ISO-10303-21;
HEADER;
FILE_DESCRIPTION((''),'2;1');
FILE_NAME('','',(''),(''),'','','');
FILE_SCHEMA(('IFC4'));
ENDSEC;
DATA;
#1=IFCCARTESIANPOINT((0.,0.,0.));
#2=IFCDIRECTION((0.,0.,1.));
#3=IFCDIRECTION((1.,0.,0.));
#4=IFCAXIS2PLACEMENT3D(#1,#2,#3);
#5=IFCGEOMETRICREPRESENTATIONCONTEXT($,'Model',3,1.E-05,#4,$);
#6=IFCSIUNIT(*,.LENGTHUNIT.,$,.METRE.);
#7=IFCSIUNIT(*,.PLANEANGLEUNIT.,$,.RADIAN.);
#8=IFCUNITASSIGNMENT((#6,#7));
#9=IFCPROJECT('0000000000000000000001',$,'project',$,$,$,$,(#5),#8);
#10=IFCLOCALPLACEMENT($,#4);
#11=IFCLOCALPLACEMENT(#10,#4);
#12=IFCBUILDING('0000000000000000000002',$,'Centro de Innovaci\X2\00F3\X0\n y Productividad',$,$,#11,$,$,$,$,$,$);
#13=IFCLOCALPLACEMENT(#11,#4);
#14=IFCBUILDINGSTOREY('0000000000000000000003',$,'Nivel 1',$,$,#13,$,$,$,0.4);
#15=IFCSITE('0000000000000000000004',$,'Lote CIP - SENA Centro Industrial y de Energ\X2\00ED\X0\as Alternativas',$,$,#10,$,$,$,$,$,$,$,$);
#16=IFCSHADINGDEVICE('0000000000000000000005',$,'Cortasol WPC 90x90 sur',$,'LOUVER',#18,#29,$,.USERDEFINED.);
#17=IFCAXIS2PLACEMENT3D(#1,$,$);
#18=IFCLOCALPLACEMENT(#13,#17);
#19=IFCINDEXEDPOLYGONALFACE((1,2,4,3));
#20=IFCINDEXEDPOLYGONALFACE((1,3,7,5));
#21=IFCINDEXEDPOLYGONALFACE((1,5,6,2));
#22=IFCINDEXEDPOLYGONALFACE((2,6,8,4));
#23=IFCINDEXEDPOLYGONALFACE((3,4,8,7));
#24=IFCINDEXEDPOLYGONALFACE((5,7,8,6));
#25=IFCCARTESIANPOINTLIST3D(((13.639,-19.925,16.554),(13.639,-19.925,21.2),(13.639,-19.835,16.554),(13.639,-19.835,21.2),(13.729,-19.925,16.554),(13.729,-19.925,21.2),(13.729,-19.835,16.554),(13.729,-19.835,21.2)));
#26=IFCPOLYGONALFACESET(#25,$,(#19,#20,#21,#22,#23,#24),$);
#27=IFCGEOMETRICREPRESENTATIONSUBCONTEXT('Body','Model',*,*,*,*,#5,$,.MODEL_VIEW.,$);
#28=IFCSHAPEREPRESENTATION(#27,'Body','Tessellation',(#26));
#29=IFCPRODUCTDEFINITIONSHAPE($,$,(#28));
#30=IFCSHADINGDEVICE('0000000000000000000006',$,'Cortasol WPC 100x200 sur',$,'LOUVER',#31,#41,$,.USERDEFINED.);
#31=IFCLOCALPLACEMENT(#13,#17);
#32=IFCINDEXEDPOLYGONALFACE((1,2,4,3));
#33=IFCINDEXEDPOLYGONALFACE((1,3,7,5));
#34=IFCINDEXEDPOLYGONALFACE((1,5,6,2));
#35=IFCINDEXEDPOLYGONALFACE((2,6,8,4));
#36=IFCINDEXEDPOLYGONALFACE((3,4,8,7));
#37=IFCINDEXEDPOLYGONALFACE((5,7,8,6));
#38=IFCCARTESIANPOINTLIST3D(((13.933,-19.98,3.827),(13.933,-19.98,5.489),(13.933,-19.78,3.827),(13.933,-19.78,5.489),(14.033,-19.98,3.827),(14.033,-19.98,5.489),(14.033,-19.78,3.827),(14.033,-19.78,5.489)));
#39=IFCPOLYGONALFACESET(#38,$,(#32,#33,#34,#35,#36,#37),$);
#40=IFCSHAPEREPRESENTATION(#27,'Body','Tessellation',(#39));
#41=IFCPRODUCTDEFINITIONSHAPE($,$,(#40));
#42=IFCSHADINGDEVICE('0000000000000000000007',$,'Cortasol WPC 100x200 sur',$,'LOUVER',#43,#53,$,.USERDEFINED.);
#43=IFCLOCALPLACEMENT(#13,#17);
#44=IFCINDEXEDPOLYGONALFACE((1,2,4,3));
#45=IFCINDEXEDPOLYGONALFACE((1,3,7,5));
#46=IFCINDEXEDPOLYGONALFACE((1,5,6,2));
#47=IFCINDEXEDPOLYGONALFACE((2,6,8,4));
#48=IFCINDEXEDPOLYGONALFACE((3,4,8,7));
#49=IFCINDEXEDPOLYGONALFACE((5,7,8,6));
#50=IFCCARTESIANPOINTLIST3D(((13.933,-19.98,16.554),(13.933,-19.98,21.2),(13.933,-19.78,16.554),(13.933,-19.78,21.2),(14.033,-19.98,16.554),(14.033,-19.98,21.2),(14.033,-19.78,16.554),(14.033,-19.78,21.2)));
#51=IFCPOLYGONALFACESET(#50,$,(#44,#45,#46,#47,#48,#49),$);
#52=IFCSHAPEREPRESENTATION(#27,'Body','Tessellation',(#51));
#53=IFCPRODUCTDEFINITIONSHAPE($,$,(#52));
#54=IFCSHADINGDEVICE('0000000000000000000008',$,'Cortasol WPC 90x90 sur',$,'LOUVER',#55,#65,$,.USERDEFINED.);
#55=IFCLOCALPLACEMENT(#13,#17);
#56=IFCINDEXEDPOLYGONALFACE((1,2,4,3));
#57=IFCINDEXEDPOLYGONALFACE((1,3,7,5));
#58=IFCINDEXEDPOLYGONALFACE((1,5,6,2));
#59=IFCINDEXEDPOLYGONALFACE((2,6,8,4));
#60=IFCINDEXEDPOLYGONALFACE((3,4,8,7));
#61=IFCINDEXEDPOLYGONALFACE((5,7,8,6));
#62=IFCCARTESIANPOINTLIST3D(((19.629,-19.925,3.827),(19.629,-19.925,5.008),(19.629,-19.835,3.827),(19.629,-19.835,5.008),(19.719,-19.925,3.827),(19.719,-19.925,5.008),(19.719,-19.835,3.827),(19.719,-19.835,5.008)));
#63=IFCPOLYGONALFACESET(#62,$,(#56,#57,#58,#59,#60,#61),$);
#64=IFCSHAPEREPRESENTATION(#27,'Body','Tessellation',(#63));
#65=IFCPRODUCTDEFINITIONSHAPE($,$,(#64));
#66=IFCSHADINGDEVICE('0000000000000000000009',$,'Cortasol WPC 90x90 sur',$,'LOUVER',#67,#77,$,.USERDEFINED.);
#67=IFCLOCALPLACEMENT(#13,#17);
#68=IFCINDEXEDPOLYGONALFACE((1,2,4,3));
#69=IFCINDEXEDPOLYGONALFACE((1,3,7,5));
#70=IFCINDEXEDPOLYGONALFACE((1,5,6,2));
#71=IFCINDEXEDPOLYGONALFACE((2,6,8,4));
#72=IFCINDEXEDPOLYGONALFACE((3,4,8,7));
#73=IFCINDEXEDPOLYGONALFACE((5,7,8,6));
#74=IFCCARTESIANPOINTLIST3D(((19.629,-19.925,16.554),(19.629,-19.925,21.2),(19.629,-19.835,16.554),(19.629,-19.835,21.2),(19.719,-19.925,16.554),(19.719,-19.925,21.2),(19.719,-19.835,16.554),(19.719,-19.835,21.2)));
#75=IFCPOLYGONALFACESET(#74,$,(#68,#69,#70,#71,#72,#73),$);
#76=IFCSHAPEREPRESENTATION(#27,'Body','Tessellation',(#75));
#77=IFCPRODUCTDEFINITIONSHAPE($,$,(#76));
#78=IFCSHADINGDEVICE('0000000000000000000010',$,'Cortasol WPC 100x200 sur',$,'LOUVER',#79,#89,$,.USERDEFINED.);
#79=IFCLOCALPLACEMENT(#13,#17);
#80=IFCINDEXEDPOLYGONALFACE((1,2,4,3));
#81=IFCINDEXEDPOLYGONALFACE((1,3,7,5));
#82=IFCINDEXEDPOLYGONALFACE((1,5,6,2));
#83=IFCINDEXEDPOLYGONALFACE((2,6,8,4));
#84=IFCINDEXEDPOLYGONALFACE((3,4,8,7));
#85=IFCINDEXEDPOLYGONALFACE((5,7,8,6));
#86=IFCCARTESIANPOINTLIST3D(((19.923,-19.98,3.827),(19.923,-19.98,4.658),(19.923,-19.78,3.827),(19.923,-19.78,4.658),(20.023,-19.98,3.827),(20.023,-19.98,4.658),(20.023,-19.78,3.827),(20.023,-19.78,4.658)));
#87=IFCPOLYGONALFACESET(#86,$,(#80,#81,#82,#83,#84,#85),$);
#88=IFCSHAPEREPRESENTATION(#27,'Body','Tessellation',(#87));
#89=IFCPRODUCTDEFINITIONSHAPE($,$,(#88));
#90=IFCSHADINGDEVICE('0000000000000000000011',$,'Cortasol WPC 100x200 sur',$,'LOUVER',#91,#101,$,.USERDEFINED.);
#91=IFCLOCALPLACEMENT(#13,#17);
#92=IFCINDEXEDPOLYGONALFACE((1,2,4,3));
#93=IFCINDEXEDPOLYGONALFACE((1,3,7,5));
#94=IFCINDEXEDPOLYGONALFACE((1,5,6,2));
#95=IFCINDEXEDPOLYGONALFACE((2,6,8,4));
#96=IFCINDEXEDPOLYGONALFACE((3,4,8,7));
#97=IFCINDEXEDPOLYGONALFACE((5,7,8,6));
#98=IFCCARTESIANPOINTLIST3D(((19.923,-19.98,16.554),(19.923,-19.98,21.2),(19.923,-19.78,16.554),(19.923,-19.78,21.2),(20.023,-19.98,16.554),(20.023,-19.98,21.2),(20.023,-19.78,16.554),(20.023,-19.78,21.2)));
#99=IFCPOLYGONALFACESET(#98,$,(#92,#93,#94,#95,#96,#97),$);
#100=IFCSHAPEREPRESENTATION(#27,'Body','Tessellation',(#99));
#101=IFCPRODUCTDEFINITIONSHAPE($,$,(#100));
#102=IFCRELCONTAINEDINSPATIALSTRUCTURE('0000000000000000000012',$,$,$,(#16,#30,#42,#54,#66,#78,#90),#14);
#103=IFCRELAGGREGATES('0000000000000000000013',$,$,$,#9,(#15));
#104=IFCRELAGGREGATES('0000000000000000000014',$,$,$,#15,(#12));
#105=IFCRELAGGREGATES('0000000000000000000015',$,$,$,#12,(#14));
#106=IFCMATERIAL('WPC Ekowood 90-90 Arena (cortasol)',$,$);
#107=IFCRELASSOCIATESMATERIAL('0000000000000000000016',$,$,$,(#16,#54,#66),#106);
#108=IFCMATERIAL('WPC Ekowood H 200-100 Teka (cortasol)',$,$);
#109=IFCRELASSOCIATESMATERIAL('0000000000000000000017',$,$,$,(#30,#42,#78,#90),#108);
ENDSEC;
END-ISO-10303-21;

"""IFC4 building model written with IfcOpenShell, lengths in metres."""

from ifc_helpers import new_model, si_unit, frame, origin_with_axes, place, context, subcontext, project, spatial, polyline, outline, extrude, material, element, save


model = new_model("IFC4")

# Units and contexts
model_context = context("Model", 3, precision=1e-05, world=origin_with_axes())
body_context = subcontext(model_context, "Body", "Model", "MODEL_VIEW")
ifc_project = project(units=[si_unit("LENGTHUNIT", "METRE"), si_unit("PLANEANGLEUNIT", "RADIAN")], contexts=[model_context])

# Site, building, storey
site_placement = place(None, origin_with_axes())
site = spatial("IfcSite", under=ifc_project, at=site_placement, Name="Lote CIP - SENA Centro Industrial y de Energías Alternativas")
building_placement = place(site_placement, origin_with_axes())
building = spatial("IfcBuilding", under=site, at=building_placement, Name="Centro de Innovación y Productividad")
storey_placement = place(building_placement, origin_with_axes())
storey = spatial("IfcBuildingStorey", under=building, at=storey_placement, Name="Nivel 1", Elevation=0.4)

# Shading devices
ifc_material_1 = material(Name="WPC Ekowood H 200-100 Teka (cortasol)")
ifc_material_2 = material(Name="WPC Ekowood 90-90 Arena (cortasol)")
shading_device_1_placement = place(storey_placement, origin_with_axes())
element("IfcShadingDevice", 1, at=shading_device_1_placement, inside=storey, material=ifc_material_2, Name="Cortasol WPC 90x90 sur", ObjectType="LOUVER", PredefinedType="USERDEFINED", context=body_context, shape_type="SweptSolid", body=[
    extrude(outline(polyline([(13.639, -19.925), (13.639, -19.835), (13.729, -19.835), (13.729, -19.925), (13.639, -19.925)])), frame((0.0, 0.0, 16.554)), (0.0, 0.0, 1.0), 4.646),
])
shading_device_2_placement = place(storey_placement, origin_with_axes())
element("IfcShadingDevice", 2, at=shading_device_2_placement, inside=storey, material=ifc_material_1, Name="Cortasol WPC 100x200 sur", ObjectType="LOUVER", PredefinedType="USERDEFINED", context=body_context, shape_type="SweptSolid", body=[
    extrude(outline(polyline([(13.933, -19.98), (13.933, -19.78), (14.033, -19.78), (14.033, -19.98), (13.933, -19.98)])), frame((0.0, 0.0, 3.827)), (0.0, 0.0, 1.0), 1.662),
])
shading_device_3_placement = place(storey_placement, origin_with_axes())
element("IfcShadingDevice", 3, at=shading_device_3_placement, inside=storey, material=ifc_material_1, Name="Cortasol WPC 100x200 sur", ObjectType="LOUVER", PredefinedType="USERDEFINED", context=body_context, shape_type="SweptSolid", body=[
    extrude(outline(polyline([(13.933, -19.98), (13.933, -19.78), (14.033, -19.78), (14.033, -19.98), (13.933, -19.98)])), frame((0.0, 0.0, 16.554)), (0.0, 0.0, 1.0), 4.646),
])
shading_device_4_placement = place(storey_placement, origin_with_axes())
element("IfcShadingDevice", 4, at=shading_device_4_placement, inside=storey, material=ifc_material_2, Name="Cortasol WPC 90x90 sur", ObjectType="LOUVER", PredefinedType="USERDEFINED", context=body_context, shape_type="SweptSolid", body=[
    extrude(outline(polyline([(19.629, -19.925), (19.629, -19.835), (19.719, -19.835), (19.719, -19.925), (19.629, -19.925)])), frame((0.0, 0.0, 3.827)), (0.0, 0.0, 1.0), 1.181),
])
shading_device_5_placement = place(storey_placement, origin_with_axes())
element("IfcShadingDevice", 5, at=shading_device_5_placement, inside=storey, material=ifc_material_2, Name="Cortasol WPC 90x90 sur", ObjectType="LOUVER", PredefinedType="USERDEFINED", context=body_context, shape_type="SweptSolid", body=[
    extrude(outline(polyline([(19.629, -19.925), (19.629, -19.835), (19.719, -19.835), (19.719, -19.925), (19.629, -19.925)])), frame((0.0, 0.0, 16.554)), (0.0, 0.0, 1.0), 4.646),
])
shading_device_6_placement = place(storey_placement, origin_with_axes())
element("IfcShadingDevice", 6, at=shading_device_6_placement, inside=storey, material=ifc_material_1, Name="Cortasol WPC 100x200 sur", ObjectType="LOUVER", PredefinedType="USERDEFINED", context=body_context, shape_type="SweptSolid", body=[
    extrude(outline(polyline([(19.923, -19.98), (19.923, -19.78), (20.023, -19.78), (20.023, -19.98), (19.923, -19.98)])), frame((0.0, 0.0, 3.827)), (0.0, 0.0, 1.0), 0.831),
])
shading_device_7_placement = place(storey_placement, origin_with_axes())
element("IfcShadingDevice", 7, at=shading_device_7_placement, inside=storey, material=ifc_material_1, Name="Cortasol WPC 100x200 sur", ObjectType="LOUVER", PredefinedType="USERDEFINED", context=body_context, shape_type="SweptSolid", body=[
    extrude(outline(polyline([(19.923, -19.98), (19.923, -19.78), (20.023, -19.78), (20.023, -19.98), (19.923, -19.98)])), frame((0.0, 0.0, 16.554)), (0.0, 0.0, 1.0), 4.646),
])

save(model, "model.ifc")
